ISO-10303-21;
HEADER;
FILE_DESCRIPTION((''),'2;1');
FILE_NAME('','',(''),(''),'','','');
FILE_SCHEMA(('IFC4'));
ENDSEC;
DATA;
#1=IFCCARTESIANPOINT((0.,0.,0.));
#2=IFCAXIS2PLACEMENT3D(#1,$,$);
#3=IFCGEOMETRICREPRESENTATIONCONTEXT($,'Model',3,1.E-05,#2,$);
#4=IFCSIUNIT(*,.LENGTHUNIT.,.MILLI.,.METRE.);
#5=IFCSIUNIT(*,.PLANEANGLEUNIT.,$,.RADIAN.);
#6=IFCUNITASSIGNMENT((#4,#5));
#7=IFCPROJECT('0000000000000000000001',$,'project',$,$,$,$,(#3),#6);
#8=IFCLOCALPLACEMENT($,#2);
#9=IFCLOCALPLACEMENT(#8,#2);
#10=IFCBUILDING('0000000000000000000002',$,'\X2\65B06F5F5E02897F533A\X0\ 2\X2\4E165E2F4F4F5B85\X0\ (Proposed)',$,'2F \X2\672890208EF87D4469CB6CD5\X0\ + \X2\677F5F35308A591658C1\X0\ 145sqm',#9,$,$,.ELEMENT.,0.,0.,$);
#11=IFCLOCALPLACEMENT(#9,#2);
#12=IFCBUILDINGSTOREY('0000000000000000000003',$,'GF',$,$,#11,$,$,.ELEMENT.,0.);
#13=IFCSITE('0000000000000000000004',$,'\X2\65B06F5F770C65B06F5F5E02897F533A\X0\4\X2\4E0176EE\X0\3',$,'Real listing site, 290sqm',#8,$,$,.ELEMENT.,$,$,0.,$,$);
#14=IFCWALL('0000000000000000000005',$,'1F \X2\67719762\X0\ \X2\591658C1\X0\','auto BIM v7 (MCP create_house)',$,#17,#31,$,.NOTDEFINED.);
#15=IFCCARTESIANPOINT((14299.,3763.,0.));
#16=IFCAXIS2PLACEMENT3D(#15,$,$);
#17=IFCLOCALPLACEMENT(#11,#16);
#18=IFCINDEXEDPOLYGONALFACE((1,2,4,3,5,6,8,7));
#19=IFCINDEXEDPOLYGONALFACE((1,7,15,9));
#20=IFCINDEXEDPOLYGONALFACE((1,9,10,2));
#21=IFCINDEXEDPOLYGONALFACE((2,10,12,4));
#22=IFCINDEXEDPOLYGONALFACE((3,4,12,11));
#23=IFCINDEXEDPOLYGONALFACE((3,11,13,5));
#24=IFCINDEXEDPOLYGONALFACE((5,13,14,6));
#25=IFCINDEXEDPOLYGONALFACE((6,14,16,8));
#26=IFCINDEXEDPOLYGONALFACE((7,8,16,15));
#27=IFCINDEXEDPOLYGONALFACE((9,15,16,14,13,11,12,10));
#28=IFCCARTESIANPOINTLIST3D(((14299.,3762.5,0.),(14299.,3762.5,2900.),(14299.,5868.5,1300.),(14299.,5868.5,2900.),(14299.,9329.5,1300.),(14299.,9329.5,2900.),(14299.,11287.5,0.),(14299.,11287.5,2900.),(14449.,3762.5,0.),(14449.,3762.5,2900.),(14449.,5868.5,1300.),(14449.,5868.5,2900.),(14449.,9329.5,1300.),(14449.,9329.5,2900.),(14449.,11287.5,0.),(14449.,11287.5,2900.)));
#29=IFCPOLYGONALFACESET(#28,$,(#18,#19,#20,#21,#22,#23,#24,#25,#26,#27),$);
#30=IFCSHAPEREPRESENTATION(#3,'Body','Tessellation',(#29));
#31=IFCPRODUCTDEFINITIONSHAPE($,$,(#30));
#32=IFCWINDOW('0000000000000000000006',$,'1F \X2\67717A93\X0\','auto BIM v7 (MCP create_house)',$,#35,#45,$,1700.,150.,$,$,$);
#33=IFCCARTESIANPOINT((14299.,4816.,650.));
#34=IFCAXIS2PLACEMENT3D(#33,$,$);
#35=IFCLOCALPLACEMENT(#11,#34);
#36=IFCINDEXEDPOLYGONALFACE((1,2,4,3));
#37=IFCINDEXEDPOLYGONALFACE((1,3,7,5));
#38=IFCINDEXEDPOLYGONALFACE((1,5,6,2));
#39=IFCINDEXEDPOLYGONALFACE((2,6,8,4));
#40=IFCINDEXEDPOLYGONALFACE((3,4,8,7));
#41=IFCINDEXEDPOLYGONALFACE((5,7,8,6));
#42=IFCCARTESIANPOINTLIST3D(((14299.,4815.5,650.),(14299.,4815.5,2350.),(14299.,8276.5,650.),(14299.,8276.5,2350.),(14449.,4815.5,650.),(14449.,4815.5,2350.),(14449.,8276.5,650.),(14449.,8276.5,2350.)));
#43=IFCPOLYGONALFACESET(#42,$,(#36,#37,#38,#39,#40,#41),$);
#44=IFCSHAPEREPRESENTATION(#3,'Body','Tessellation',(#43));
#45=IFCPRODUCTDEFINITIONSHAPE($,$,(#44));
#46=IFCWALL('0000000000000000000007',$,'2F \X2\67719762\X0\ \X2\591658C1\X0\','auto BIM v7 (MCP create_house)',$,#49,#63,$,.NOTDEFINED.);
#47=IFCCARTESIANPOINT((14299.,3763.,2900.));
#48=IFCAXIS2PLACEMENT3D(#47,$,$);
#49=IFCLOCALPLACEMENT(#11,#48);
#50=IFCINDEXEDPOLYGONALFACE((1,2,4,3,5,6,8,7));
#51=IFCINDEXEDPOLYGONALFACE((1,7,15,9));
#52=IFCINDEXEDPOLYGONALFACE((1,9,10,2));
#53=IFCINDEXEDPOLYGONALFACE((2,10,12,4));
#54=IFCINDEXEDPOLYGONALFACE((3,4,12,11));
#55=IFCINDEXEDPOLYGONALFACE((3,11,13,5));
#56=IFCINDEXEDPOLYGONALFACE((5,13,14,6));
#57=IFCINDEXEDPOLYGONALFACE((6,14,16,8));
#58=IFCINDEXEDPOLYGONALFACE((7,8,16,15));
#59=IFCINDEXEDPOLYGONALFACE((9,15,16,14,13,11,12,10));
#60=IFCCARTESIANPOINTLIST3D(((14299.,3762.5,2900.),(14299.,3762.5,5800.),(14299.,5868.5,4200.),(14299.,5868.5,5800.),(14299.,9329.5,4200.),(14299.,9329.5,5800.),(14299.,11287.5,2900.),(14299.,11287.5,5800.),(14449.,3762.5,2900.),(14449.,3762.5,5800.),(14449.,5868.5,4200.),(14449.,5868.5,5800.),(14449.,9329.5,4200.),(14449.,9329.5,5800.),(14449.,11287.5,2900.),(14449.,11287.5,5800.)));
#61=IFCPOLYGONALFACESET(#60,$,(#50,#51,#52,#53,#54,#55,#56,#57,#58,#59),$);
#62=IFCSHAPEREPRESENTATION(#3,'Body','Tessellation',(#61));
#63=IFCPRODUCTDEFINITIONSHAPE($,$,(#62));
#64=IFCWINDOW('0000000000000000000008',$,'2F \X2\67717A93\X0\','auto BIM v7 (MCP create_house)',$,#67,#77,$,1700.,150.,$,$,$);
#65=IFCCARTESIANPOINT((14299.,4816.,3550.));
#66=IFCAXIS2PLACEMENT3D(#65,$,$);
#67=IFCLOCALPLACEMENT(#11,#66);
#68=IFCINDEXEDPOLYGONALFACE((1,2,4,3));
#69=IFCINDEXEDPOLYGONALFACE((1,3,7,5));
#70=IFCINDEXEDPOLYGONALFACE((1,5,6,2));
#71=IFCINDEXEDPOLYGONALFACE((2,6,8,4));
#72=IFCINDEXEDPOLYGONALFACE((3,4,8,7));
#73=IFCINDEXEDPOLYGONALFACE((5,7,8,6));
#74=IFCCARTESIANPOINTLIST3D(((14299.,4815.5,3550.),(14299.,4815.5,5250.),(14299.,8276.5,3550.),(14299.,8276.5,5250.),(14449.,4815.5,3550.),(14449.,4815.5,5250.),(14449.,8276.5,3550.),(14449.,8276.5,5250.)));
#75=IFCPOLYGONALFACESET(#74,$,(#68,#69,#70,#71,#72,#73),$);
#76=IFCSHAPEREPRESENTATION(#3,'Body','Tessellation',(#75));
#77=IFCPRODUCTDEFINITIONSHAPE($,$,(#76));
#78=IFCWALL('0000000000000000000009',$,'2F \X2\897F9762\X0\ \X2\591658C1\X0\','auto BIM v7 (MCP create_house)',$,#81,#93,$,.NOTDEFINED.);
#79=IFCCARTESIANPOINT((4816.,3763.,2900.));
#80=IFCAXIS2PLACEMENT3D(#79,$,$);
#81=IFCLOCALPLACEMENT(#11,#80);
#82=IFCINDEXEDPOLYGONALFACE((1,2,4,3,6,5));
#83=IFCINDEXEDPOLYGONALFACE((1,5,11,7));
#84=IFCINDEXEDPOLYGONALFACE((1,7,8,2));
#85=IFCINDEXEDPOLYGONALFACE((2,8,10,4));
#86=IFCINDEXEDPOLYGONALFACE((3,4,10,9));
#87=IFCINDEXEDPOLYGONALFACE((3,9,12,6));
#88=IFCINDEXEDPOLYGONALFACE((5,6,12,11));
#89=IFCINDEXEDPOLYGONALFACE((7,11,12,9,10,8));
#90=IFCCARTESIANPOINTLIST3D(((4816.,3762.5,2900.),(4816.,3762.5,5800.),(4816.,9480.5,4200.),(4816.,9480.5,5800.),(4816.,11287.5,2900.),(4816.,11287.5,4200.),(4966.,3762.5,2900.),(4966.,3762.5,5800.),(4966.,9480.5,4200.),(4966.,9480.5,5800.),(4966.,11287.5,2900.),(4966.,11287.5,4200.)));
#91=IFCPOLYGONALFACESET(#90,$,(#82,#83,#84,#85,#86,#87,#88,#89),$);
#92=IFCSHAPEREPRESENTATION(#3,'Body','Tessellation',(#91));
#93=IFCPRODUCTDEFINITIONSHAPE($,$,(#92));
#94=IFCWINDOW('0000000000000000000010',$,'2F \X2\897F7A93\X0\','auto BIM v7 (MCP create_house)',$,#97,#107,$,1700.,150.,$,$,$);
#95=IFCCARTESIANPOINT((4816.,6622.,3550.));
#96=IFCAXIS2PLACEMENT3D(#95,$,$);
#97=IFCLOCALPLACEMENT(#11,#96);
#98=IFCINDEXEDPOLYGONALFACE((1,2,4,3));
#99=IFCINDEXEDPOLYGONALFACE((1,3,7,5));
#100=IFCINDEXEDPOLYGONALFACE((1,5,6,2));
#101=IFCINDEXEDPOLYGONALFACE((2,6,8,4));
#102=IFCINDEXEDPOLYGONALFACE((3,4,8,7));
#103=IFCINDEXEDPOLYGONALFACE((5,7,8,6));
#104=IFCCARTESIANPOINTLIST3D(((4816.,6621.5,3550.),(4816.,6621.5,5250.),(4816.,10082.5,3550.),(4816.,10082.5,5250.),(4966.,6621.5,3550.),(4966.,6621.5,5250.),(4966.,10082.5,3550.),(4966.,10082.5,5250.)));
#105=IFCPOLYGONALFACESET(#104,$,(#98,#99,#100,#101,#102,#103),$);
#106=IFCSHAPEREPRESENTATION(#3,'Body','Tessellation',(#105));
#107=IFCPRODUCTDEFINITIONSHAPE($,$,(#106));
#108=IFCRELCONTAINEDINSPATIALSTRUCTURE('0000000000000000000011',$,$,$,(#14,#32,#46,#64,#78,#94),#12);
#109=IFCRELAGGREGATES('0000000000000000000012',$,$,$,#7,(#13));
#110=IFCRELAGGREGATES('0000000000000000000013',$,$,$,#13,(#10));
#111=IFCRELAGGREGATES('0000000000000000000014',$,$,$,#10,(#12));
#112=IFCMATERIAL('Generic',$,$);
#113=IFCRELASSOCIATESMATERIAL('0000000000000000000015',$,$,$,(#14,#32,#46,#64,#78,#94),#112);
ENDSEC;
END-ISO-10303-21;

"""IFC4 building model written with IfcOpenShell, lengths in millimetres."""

from ifc_helpers import new_model, si_unit, frame, frame_2d, origin, place, context, project, spatial, rectangle, extrude, material, element, fill, save


model = new_model("IFC4")

# Units and contexts
model_context = context("Model", 3, precision=1e-05, world=origin())
ifc_project = project(units=[si_unit("LENGTHUNIT", "METRE", prefix="MILLI"), si_unit("PLANEANGLEUNIT", "RADIAN")], contexts=[model_context])

# Site, building, storey
site_placement = place(None, origin())
site = spatial("IfcSite", under=ifc_project, at=site_placement, Name="新潟県新潟市西区4丁目3", ObjectType="Real listing site, 290sqm", CompositionType="ELEMENT", RefElevation=0.0)
building_placement = place(site_placement, origin())
building = spatial("IfcBuilding", under=site, at=building_placement, Name="新潟市西区 2世帯住宅 (Proposed)", ObjectType="2F 木造軸組構法 + 板張り外壁 145sqm", CompositionType="ELEMENT", ElevationOfRefHeight=0.0, ElevationOfTerrain=0.0)
storey_placement = place(building_placement, origin())
storey = spatial("IfcBuildingStorey", under=building, at=storey_placement, Name="GF", CompositionType="ELEMENT", Elevation=0.0)

# Shared definitions
ifc_material = material(Name="Generic")

# Wall, opening, window
wall_1_placement = place(storey_placement, frame((14299.0, 3763.0, 0.0)))
wall_1 = element("IfcWall", 1, at=wall_1_placement, inside=storey, material=ifc_material, Name="1F 東面 外壁", Description="auto BIM v7 (MCP create_house)", PredefinedType="NOTDEFINED", context=model_context, shape_type="SweptSolid", body=[
    extrude(rectangle(XDim=150.0, YDim=7525.0, at=frame_2d((75.0, 3762.0))), frame((14299.0, 3763.0, 0.0)), (0.0, 0.0, 1.0), 2900.0),
])
opening_1_placement = place(storey_placement, frame((14299.0, 4816.0, 650.0)))
opening_1 = element("IfcOpeningElement", 2, at=opening_1_placement, cuts=wall_1, PredefinedType="NOTDEFINED", context=model_context, shape_type="SweptSolid", body=[
    extrude(rectangle(XDim=150.0, YDim=3461.0, at=frame_2d((75.0, 1730.0))), frame((14299.0, 4816.0, 650.0)), (0.0, 0.0, 1.0), 1700.0),
])
window_1_placement = place(storey_placement, frame((14299.0, 4816.0, 650.0)))
window_1 = element("IfcWindow", 3, at=window_1_placement, inside=storey, material=ifc_material, Name="1F 東窓", Description="auto BIM v7 (MCP create_house)", OverallHeight=1700.0, OverallWidth=150.0, context=model_context, shape_type="SweptSolid", body=[
    extrude(rectangle(XDim=150.0, YDim=3461.0, at=frame_2d((75.0, 1730.0))), frame((14299.0, 4816.0, 650.0)), (0.0, 0.0, 1.0), 1700.0),
])
fill(opening_1, window_1)

# Walls, openings, windows
wall_2_placement = place(storey_placement, frame((14299.0, 3763.0, 2900.0)))
wall_2 = element("IfcWall", 4, at=wall_2_placement, inside=storey, material=ifc_material, Name="2F 東面 外壁", Description="auto BIM v7 (MCP create_house)", PredefinedType="NOTDEFINED", context=model_context, shape_type="SweptSolid", body=[
    extrude(rectangle(XDim=150.0, YDim=7525.0, at=frame_2d((75.0, 3762.0))), frame((14299.0, 3763.0, 2900.0)), (0.0, 0.0, 1.0), 2900.0),
])
opening_2_placement = place(storey_placement, frame((14299.0, 4816.0, 3550.0)))
opening_2 = element("IfcOpeningElement", 5, at=opening_2_placement, cuts=wall_2, PredefinedType="NOTDEFINED", context=model_context, shape_type="SweptSolid", body=[
    extrude(rectangle(XDim=150.0, YDim=3461.0, at=frame_2d((75.0, 1730.0))), frame((14299.0, 4816.0, 3550.0)), (0.0, 0.0, 1.0), 1700.0),
])
window_2_placement = place(storey_placement, frame((14299.0, 4816.0, 3550.0)))
window_2 = element("IfcWindow", 6, at=window_2_placement, inside=storey, material=ifc_material, Name="2F 東窓", Description="auto BIM v7 (MCP create_house)", OverallHeight=1700.0, OverallWidth=150.0, context=model_context, shape_type="SweptSolid", body=[
    extrude(rectangle(XDim=150.0, YDim=3461.0, at=frame_2d((75.0, 1730.0))), frame((14299.0, 4816.0, 3550.0)), (0.0, 0.0, 1.0), 1700.0),
])
fill(opening_2, window_2)
wall_3_placement = place(storey_placement, frame((4816.0, 3763.0, 2900.0)))
wall_3 = element("IfcWall", 7, at=wall_3_placement, inside=storey, material=ifc_material, Name="2F 西面 外壁", Description="auto BIM v7 (MCP create_house)", PredefinedType="NOTDEFINED", context=model_context, shape_type="SweptSolid", body=[
    extrude(rectangle(XDim=150.0, YDim=7525.0, at=frame_2d((75.0, 3762.0))), frame((4816.0, 3763.0, 2900.0)), (0.0, 0.0, 1.0), 2900.0),
])
opening_3_placement = place(storey_placement, frame((4816.0, 6622.0, 3550.0)))
opening_3 = element("IfcOpeningElement", 8, at=opening_3_placement, cuts=wall_3, PredefinedType="NOTDEFINED", context=model_context, shape_type="SweptSolid", body=[
    extrude(rectangle(XDim=150.0, YDim=3461.0, at=frame_2d((75.0, 1730.0))), frame((4816.0, 6622.0, 3550.0)), (0.0, 0.0, 1.0), 1700.0),
])
window_3_placement = place(storey_placement, frame((4816.0, 6622.0, 3550.0)))
window_3 = element("IfcWindow", 9, at=window_3_placement, inside=storey, material=ifc_material, Name="2F 西窓", Description="auto BIM v7 (MCP create_house)", OverallHeight=1700.0, OverallWidth=150.0, context=model_context, shape_type="SweptSolid", body=[
    extrude(rectangle(XDim=150.0, YDim=3461.0, at=frame_2d((75.0, 1730.0))), frame((4816.0, 6622.0, 3550.0)), (0.0, 0.0, 1.0), 1700.0),
])
fill(opening_3, window_3)

save(model, "model.ifc")
